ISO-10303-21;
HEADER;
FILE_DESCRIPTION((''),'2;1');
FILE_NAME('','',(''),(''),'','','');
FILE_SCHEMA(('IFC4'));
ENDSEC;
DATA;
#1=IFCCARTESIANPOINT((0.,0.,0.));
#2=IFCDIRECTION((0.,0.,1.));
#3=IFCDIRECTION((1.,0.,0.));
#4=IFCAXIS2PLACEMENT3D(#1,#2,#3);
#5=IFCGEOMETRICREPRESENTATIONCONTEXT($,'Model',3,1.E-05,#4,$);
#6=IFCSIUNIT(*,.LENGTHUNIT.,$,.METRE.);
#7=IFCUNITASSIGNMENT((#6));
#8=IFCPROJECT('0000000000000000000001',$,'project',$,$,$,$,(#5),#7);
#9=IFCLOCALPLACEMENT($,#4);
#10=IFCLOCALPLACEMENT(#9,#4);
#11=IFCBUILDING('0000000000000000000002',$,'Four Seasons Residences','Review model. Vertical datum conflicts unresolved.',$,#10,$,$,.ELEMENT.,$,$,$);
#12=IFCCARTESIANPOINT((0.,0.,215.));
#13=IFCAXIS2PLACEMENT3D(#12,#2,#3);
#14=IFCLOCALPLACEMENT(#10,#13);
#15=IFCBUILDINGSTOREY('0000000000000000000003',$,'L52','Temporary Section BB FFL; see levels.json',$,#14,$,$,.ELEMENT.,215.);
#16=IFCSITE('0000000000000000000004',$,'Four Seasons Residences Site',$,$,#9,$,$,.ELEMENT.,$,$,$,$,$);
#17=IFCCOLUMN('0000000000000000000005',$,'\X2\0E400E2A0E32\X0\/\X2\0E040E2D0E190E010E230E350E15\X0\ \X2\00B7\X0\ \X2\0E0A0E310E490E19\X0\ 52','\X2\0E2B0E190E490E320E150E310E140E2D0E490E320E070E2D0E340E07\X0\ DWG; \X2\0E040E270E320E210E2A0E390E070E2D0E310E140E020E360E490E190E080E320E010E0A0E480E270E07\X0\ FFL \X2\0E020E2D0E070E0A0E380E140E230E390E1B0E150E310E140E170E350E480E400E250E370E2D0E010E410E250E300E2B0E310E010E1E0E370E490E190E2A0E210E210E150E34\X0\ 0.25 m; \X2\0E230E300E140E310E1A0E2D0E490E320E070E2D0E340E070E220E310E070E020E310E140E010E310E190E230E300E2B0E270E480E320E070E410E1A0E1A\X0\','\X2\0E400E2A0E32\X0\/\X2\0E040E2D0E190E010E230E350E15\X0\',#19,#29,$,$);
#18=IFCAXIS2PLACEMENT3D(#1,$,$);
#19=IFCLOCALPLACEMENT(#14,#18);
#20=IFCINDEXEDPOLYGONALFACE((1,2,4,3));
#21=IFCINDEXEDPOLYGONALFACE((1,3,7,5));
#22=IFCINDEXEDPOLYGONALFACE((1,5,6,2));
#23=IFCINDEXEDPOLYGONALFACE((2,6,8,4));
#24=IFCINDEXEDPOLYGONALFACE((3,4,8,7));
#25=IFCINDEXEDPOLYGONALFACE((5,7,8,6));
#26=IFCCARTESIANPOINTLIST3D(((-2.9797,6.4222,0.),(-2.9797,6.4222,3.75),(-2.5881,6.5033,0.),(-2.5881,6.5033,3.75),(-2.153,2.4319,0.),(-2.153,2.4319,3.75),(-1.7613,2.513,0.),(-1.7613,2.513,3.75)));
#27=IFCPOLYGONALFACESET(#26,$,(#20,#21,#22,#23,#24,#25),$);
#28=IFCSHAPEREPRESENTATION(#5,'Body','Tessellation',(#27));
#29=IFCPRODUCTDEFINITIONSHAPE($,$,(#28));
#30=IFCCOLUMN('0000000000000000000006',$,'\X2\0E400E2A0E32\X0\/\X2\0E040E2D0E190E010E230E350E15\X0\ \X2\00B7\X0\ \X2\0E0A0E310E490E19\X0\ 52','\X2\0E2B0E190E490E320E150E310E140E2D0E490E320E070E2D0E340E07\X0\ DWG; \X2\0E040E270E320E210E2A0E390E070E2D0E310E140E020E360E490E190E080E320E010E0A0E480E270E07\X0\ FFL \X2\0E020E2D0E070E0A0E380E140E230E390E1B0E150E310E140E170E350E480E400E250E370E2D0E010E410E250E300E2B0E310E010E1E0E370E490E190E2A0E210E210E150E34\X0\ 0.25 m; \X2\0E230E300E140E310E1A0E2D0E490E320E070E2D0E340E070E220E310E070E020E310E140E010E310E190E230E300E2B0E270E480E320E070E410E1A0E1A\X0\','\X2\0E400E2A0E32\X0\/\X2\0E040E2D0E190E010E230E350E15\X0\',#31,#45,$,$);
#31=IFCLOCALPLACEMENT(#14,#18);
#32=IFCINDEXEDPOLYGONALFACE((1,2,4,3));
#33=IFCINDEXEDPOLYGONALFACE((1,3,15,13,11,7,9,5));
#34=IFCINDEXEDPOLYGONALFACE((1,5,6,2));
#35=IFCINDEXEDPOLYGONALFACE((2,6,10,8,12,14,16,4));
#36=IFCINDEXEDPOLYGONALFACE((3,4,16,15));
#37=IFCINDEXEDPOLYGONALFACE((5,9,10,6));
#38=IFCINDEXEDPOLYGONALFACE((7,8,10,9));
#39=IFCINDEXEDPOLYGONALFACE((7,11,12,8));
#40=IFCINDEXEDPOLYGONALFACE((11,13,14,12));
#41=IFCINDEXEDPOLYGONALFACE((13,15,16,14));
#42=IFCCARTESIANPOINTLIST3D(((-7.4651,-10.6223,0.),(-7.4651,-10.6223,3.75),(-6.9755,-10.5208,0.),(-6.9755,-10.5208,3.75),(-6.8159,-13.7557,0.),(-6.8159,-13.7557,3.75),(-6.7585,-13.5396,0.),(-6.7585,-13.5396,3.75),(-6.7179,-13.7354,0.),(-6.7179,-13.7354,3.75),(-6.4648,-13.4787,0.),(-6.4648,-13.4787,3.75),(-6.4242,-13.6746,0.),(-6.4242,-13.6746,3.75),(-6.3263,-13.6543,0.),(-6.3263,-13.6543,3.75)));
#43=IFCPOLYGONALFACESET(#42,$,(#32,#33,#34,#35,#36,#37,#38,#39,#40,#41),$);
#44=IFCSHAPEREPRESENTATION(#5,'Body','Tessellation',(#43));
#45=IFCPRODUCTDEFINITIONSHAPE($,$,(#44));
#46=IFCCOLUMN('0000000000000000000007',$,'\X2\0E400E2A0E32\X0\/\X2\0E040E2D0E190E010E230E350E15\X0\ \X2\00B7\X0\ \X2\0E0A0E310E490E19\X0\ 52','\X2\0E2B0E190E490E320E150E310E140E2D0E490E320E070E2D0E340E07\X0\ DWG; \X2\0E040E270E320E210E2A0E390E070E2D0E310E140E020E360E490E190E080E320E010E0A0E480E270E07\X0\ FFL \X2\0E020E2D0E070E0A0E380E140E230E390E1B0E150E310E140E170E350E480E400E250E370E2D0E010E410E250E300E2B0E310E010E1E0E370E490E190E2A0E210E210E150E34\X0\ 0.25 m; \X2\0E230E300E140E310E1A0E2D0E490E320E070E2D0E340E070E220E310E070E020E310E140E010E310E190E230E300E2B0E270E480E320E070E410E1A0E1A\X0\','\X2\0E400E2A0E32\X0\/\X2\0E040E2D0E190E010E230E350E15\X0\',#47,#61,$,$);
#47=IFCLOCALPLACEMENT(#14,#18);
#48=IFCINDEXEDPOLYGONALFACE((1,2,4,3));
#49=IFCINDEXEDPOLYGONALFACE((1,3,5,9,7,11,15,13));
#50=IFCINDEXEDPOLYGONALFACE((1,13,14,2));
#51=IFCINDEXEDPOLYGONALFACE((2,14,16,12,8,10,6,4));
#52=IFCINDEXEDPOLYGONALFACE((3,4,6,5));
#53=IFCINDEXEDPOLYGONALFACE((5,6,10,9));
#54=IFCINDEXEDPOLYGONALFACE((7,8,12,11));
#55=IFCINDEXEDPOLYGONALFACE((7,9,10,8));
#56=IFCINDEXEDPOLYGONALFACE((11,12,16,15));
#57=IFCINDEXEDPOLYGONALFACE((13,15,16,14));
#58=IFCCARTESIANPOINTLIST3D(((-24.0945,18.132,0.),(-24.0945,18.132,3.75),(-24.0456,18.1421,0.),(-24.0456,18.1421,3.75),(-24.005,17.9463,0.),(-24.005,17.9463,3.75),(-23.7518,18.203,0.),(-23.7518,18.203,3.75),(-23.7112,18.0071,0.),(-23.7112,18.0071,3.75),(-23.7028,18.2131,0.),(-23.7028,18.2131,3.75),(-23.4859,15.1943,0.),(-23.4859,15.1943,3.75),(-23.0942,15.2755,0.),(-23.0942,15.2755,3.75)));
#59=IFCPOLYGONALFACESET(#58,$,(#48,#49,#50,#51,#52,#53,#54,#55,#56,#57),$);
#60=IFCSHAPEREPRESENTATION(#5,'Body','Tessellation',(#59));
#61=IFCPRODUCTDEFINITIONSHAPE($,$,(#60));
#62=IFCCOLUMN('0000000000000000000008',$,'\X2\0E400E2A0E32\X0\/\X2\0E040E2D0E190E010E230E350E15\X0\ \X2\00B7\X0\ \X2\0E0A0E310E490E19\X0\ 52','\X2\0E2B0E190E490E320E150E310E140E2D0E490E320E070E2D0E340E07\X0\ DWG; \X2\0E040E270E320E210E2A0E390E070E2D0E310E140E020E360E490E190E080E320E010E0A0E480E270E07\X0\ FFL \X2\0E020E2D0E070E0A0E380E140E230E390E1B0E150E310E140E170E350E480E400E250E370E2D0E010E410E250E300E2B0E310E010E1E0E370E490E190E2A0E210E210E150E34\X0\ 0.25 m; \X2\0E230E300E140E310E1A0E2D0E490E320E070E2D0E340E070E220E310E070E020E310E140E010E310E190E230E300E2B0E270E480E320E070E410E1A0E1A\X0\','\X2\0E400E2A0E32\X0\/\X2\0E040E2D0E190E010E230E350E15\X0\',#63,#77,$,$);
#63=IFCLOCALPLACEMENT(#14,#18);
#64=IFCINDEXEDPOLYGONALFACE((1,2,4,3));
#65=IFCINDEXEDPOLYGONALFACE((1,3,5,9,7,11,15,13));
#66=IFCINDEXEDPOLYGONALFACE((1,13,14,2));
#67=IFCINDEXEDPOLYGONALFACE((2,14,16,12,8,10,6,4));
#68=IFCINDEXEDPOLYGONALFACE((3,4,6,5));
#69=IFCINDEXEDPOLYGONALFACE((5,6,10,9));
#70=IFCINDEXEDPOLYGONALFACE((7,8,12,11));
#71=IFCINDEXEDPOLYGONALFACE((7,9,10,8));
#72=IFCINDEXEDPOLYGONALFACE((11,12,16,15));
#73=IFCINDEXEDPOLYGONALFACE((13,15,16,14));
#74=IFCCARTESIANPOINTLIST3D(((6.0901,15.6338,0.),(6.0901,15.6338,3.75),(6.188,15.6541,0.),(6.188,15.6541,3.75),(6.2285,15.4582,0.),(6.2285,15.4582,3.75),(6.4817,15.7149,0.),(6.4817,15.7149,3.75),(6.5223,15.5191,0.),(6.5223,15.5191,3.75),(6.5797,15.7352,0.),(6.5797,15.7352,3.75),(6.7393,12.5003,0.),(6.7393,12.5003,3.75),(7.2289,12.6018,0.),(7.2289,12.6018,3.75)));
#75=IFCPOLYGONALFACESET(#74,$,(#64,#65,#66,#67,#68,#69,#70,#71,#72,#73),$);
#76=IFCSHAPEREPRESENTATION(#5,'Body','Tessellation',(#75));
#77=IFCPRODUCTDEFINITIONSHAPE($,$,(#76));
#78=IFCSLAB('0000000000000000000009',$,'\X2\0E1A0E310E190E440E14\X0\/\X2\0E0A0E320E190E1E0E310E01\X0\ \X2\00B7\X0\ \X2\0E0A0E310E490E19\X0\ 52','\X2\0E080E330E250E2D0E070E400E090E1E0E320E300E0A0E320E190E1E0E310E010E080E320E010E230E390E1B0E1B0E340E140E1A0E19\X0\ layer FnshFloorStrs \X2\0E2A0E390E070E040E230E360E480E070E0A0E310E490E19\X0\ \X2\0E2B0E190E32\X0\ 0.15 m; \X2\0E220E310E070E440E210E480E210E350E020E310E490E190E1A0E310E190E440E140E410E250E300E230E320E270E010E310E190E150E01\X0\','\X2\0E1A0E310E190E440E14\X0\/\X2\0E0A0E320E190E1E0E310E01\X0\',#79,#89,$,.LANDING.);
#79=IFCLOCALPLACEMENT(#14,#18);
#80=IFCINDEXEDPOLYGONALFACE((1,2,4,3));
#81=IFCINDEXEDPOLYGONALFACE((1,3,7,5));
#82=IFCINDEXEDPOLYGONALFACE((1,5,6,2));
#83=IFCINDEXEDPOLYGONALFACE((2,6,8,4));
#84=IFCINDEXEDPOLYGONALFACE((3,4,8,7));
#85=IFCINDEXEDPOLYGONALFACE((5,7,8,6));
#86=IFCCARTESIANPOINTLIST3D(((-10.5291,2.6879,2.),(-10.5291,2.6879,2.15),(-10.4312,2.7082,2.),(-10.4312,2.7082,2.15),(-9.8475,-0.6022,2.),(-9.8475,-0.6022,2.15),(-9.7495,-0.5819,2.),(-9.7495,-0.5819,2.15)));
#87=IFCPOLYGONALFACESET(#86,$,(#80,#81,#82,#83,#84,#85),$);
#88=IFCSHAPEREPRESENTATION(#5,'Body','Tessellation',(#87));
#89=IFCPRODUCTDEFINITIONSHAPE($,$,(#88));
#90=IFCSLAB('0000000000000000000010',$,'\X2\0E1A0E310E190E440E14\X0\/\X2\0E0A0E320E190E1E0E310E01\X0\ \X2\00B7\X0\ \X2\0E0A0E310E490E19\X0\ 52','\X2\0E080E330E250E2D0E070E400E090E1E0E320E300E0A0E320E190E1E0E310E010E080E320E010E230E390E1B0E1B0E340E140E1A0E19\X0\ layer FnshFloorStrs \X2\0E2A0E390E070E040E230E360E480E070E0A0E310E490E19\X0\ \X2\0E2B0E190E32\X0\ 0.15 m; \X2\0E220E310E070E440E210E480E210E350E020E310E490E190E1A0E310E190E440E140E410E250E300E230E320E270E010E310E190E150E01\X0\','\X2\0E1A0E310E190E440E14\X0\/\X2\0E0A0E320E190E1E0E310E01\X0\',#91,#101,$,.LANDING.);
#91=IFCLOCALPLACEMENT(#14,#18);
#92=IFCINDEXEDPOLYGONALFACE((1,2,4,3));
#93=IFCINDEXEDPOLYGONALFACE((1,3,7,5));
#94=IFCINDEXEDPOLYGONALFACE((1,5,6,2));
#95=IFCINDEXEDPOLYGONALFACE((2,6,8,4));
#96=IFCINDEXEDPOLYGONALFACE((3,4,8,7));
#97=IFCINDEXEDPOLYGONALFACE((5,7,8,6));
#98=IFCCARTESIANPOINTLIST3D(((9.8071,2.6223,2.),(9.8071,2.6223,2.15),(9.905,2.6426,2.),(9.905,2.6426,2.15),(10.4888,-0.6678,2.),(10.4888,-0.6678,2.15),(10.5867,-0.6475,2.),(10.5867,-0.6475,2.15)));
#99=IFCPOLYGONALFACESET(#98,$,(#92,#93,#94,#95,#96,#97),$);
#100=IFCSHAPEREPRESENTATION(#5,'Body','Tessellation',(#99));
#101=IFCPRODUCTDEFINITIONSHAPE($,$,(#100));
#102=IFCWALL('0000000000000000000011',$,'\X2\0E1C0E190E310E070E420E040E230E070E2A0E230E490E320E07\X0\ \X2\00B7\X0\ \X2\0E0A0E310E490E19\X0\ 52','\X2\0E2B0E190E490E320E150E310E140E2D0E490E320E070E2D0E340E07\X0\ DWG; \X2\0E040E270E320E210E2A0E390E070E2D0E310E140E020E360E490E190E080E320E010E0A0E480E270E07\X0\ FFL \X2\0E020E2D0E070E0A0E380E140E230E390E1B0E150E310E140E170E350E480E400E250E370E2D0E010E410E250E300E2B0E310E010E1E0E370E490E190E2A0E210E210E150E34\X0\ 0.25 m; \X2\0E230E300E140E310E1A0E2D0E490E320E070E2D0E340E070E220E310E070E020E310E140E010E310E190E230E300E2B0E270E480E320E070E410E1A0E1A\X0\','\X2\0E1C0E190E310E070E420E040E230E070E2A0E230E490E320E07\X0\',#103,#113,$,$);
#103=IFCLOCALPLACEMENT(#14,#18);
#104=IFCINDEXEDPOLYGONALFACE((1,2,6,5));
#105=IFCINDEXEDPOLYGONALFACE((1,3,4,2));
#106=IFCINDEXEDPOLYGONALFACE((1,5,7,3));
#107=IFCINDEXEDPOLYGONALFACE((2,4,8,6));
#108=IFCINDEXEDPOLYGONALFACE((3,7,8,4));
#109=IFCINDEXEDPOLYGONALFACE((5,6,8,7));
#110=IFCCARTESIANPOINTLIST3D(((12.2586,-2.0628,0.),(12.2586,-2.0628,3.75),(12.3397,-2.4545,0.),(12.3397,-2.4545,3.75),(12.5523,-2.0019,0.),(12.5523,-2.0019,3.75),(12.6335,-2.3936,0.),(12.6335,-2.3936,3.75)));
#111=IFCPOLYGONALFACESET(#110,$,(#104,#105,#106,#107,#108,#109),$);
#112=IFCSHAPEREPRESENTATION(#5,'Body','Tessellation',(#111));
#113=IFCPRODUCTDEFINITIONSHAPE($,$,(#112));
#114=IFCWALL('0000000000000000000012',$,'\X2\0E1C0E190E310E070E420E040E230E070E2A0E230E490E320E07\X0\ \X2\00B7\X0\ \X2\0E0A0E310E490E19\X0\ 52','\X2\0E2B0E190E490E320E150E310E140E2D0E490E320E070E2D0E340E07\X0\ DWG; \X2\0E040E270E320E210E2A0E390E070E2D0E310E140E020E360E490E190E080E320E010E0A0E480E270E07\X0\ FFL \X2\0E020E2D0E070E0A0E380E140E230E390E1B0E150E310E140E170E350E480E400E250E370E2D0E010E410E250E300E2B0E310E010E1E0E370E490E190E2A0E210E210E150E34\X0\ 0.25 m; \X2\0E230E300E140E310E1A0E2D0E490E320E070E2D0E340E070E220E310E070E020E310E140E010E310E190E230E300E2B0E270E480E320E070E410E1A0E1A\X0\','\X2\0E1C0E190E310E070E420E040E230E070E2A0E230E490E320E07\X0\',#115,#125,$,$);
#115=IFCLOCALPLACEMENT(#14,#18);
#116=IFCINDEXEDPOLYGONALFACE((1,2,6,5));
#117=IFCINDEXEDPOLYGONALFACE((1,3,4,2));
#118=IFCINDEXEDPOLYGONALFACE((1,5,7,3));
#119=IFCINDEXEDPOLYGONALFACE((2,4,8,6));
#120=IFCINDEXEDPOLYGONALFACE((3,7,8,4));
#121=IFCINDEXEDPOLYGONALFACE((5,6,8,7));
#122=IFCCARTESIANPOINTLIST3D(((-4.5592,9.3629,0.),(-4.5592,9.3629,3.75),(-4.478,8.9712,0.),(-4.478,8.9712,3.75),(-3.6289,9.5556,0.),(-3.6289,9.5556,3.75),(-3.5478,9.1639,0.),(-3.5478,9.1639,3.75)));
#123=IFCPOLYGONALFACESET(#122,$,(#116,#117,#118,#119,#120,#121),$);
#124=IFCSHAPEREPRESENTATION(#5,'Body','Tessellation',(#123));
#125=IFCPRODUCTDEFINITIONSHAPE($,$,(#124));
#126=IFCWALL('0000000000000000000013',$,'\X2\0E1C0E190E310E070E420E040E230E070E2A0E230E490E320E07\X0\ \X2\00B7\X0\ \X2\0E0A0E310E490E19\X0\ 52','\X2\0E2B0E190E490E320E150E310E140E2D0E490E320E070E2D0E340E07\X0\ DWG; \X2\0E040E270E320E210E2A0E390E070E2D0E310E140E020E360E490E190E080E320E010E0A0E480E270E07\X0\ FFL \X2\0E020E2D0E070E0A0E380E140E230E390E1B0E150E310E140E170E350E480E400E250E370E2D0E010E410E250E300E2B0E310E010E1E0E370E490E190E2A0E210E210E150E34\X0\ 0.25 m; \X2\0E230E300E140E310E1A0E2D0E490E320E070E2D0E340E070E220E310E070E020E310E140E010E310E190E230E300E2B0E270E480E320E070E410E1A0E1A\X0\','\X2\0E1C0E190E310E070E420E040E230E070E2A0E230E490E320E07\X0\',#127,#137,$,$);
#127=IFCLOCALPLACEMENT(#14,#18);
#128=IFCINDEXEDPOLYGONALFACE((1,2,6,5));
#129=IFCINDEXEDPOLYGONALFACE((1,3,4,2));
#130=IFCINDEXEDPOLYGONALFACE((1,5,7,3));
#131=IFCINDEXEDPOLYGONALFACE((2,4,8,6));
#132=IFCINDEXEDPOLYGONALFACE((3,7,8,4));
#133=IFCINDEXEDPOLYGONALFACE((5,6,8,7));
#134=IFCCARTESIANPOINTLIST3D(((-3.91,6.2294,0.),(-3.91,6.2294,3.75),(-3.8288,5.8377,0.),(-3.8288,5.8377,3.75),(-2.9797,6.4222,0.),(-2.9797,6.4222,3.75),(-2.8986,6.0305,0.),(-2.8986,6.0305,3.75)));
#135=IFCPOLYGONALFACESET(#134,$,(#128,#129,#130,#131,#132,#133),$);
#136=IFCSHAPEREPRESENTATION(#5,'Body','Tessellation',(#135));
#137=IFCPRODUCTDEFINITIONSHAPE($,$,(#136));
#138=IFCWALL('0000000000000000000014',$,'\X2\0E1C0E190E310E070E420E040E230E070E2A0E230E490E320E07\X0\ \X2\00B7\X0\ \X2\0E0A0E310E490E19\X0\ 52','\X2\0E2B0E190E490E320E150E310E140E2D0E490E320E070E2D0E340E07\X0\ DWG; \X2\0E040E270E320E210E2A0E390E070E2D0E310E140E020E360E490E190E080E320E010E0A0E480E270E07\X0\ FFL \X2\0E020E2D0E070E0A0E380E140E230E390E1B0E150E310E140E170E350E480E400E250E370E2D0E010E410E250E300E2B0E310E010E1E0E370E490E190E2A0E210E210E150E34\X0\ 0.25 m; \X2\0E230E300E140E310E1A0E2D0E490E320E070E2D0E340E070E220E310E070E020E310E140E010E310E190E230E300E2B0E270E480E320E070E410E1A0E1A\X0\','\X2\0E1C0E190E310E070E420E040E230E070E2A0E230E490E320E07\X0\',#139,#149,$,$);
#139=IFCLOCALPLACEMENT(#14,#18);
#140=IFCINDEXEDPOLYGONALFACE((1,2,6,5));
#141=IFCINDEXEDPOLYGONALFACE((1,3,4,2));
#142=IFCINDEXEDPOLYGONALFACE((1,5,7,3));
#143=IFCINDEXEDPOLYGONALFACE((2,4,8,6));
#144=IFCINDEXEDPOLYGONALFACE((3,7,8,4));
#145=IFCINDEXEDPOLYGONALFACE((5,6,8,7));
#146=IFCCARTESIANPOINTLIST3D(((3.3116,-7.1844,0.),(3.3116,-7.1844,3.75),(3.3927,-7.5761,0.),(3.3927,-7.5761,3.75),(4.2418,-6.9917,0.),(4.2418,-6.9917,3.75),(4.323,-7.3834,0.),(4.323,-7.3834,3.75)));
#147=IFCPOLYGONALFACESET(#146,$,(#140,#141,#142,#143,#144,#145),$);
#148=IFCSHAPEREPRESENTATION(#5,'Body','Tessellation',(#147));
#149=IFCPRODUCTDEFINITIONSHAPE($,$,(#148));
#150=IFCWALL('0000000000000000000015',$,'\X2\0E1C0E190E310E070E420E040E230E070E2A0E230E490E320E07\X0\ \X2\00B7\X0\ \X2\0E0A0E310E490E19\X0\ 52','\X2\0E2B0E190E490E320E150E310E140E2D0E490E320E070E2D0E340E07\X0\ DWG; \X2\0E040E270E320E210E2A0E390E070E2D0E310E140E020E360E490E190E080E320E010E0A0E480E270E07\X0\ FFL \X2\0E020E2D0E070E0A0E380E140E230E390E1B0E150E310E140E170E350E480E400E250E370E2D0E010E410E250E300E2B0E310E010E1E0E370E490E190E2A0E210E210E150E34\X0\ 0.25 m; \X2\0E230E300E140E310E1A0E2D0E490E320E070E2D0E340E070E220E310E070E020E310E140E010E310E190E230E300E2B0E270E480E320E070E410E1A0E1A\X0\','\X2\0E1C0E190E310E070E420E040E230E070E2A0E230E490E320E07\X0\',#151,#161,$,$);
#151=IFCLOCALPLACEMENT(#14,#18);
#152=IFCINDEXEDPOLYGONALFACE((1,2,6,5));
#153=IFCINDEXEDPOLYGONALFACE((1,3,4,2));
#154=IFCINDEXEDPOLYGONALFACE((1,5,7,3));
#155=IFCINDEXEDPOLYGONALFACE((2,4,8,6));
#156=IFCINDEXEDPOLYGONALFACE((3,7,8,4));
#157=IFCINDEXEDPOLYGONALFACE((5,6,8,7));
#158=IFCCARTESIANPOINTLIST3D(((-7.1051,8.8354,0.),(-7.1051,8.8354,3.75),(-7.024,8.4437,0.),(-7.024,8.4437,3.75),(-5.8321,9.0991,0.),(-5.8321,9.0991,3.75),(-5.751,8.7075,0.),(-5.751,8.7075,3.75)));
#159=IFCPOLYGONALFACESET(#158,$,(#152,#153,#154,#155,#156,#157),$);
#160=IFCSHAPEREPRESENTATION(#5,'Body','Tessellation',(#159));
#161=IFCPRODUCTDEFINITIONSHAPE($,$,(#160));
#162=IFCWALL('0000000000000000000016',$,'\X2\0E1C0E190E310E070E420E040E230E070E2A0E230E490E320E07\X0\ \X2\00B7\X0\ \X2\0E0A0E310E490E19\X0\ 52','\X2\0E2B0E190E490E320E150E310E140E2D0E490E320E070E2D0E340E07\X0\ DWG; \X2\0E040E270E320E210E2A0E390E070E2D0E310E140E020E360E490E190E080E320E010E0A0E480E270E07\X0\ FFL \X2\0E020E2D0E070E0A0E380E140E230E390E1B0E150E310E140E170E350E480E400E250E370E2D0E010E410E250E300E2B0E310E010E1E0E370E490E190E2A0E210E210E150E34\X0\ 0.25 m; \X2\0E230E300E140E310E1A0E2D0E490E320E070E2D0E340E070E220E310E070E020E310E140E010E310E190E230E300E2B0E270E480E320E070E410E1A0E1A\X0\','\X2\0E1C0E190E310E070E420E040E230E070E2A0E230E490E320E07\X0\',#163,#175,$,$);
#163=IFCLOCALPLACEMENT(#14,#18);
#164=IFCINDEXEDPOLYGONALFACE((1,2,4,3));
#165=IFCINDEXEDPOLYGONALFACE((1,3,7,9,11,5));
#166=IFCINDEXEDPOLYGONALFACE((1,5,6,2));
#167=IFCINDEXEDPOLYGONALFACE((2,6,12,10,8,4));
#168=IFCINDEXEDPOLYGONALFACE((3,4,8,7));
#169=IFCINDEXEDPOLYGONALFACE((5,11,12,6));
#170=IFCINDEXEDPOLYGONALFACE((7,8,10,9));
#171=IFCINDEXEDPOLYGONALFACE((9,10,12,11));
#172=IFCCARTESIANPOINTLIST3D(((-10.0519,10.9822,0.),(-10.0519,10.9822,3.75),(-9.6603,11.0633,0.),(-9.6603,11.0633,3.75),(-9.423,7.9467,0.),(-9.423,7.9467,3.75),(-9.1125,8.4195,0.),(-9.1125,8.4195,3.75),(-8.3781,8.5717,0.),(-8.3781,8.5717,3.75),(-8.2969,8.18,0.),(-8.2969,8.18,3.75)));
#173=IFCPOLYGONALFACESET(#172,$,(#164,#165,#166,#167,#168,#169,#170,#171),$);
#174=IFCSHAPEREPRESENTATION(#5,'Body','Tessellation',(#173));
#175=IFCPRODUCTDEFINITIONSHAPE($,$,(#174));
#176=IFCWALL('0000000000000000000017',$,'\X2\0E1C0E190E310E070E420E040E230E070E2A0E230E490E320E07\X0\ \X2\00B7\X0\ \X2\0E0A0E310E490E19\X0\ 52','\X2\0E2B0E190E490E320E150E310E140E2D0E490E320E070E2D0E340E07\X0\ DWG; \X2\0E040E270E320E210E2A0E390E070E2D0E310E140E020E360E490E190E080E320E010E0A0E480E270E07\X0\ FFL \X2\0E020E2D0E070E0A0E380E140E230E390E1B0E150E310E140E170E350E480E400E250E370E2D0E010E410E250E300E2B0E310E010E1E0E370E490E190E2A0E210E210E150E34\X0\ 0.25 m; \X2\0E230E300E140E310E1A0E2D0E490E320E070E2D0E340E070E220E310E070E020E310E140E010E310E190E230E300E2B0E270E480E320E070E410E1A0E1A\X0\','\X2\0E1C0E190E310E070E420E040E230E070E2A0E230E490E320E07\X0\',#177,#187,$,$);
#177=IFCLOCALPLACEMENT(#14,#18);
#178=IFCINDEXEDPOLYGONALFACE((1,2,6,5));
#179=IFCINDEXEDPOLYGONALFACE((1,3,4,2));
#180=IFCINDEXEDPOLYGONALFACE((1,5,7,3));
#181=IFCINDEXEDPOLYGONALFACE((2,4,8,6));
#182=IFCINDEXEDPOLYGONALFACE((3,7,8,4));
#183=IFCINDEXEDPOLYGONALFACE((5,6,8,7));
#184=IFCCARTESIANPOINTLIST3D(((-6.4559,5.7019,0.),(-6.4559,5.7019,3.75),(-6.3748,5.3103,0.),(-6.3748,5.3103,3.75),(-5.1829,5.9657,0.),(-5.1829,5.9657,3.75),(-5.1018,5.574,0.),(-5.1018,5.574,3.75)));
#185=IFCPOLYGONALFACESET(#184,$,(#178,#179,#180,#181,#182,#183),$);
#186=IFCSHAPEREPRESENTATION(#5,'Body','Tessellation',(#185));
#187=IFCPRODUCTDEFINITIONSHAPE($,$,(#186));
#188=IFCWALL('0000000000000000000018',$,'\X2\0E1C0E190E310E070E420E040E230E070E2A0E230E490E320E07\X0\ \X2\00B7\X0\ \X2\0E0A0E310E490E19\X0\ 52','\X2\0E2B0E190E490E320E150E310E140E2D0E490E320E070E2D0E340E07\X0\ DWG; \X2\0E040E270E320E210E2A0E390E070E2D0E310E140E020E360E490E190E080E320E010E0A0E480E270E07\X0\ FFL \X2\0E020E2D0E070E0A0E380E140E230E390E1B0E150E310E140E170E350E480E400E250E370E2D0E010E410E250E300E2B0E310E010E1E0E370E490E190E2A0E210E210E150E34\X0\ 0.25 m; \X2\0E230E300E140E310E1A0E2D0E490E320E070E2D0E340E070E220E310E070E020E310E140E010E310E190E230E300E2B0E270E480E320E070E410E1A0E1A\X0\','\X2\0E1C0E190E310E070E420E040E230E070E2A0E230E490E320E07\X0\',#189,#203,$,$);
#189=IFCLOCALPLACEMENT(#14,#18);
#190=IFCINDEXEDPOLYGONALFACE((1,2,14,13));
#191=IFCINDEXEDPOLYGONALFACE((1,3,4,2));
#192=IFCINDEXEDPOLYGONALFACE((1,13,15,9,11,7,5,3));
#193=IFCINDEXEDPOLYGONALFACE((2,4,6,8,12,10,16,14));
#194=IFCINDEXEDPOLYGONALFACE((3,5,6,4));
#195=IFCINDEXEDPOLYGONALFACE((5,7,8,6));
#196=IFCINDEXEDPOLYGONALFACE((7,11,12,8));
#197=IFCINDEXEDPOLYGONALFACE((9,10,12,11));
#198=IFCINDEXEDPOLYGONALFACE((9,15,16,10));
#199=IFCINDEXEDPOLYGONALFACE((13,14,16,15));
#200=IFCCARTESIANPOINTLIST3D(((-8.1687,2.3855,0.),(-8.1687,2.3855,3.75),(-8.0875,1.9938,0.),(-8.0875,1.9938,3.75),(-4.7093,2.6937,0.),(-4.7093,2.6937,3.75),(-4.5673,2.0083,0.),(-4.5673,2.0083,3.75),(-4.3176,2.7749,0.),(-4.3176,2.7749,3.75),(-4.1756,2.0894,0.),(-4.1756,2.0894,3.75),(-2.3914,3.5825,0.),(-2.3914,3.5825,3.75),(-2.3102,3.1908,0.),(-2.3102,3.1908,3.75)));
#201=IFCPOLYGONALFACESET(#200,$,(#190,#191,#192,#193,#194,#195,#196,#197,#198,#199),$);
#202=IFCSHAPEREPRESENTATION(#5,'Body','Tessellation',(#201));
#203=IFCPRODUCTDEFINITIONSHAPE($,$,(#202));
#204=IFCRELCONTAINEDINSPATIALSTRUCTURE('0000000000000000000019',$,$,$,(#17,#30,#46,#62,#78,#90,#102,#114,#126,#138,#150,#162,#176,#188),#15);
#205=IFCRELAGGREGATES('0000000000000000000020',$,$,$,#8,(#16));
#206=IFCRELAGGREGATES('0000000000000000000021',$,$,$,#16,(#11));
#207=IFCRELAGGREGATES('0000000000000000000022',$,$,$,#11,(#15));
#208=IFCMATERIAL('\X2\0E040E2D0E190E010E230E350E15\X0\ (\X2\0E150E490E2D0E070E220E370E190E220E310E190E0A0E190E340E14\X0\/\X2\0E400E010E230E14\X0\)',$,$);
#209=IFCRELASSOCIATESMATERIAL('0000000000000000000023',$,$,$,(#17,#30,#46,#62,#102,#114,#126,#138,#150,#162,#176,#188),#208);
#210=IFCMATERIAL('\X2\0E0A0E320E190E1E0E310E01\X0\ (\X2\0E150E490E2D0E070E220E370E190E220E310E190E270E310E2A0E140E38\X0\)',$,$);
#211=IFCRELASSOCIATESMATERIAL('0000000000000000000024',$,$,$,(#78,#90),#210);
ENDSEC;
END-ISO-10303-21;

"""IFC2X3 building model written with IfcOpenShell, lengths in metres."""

from ifc_helpers import new_model, si_unit, frame, origin_with_axes, place, context, project, spatial, polyline, outline, extrude, material, element, save


model = new_model("IFC2X3")

# Units and contexts
model_context = context("Model", 3, precision=1e-05, world=origin_with_axes())
ifc_project = project(units=[si_unit("LENGTHUNIT", "METRE")], contexts=[model_context])

# Site, building, storey
site_placement = place(None, origin_with_axes())
site = spatial("IfcSite", under=ifc_project, at=site_placement, Name="Four Seasons Residences Site", CompositionType="ELEMENT")
building_placement = place(site_placement, origin_with_axes())
building = spatial("IfcBuilding", under=site, at=building_placement, Name="Four Seasons Residences", Description="Review model. Vertical datum conflicts unresolved.", CompositionType="ELEMENT")
storey_placement = place(building_placement, frame((0.0, 0.0, 215.0), z_axis=(0.0, 0.0, 1.0), x_axis=(1.0, 0.0, 0.0)))
storey = spatial("IfcBuildingStorey", under=building, at=storey_placement, Name="L52", Description="Temporary Section BB FFL; see levels.json", CompositionType="ELEMENT", Elevation=215.0)

# Columns
ifc_material_1 = material(Name="คอนกรีต (ต้องยืนยันชนิด/เกรด)")
column_1_placement = place(storey_placement, origin_with_axes())
element("IfcColumn", 1, at=column_1_placement, inside=storey, material=ifc_material_1, Name="เสา/คอนกรีต · ชั้น 52", Description="หน้าตัดอ้างอิง DWG; ความสูงอัดขึ้นจากช่วง FFL ของชุดรูปตัดที่เลือกและหักพื้นสมมติ 0.25 m; ระดับอ้างอิงยังขัดกันระหว่างแบบ", ObjectType="เสา/คอนกรีต", context=model_context, shape_type="SweptSolid", body=[
    extrude(outline(polyline([(-2.5881, 6.5033), (-1.7613, 2.513), (-2.153, 2.4319), (-2.9797, 6.4222), (-2.5881, 6.5033)])), origin_with_axes(), (0.0, 0.0, 1.0), 3.75),
])
column_2_placement = place(storey_placement, origin_with_axes())
element("IfcColumn", 2, at=column_2_placement, inside=storey, material=ifc_material_1, Name="เสา/คอนกรีต · ชั้น 52", Description="หน้าตัดอ้างอิง DWG; ความสูงอัดขึ้นจากช่วง FFL ของชุดรูปตัดที่เลือกและหักพื้นสมมติ 0.25 m; ระดับอ้างอิงยังขัดกันระหว่างแบบ", ObjectType="เสา/คอนกรีต", context=model_context, shape_type="SweptSolid", body=[
    extrude(outline(polyline([(-6.9755, -10.5208), (-7.4651, -10.6223), (-6.8159, -13.7557), (-6.7179, -13.7354), (-6.7585, -13.5396), (-6.4648, -13.4787), (-6.4242, -13.6746), (-6.3263, -13.6543), (-6.9755, -10.5208)])), origin_with_axes(), (0.0, 0.0, 1.0), 3.75),
])
column_3_placement = place(storey_placement, origin_with_axes())
element("IfcColumn", 3, at=column_3_placement, inside=storey, material=ifc_material_1, Name="เสา/คอนกรีต · ชั้น 52", Description="หน้าตัดอ้างอิง DWG; ความสูงอัดขึ้นจากช่วง FFL ของชุดรูปตัดที่เลือกและหักพื้นสมมติ 0.25 m; ระดับอ้างอิงยังขัดกันระหว่างแบบ", ObjectType="เสา/คอนกรีต", context=model_context, shape_type="SweptSolid", body=[
    extrude(outline(polyline([(-23.7028, 18.2131), (-23.7518, 18.203), (-23.7112, 18.0071), (-24.005, 17.9463), (-24.0456, 18.1421), (-24.0945, 18.132), (-23.4859, 15.1943), (-23.0942, 15.2755), (-23.7028, 18.2131)])), origin_with_axes(), (0.0, 0.0, 1.0), 3.75),
])
column_4_placement = place(storey_placement, origin_with_axes())
element("IfcColumn", 4, at=column_4_placement, inside=storey, material=ifc_material_1, Name="เสา/คอนกรีต · ชั้น 52", Description="หน้าตัดอ้างอิง DWG; ความสูงอัดขึ้นจากช่วง FFL ของชุดรูปตัดที่เลือกและหักพื้นสมมติ 0.25 m; ระดับอ้างอิงยังขัดกันระหว่างแบบ", ObjectType="เสา/คอนกรีต", context=model_context, shape_type="SweptSolid", body=[
    extrude(outline(polyline([(6.5797, 15.7352), (6.4817, 15.7149), (6.5223, 15.5191), (6.2285, 15.4582), (6.188, 15.6541), (6.0901, 15.6338), (6.7393, 12.5003), (7.2289, 12.6018), (6.5797, 15.7352)])), origin_with_axes(), (0.0, 0.0, 1.0), 3.75),
])

# Slabs
ifc_material_2 = material(Name="ชานพัก (ต้องยืนยันวัสดุ)")
slab_1_placement = place(storey_placement, origin_with_axes())
element("IfcSlab", 5, at=slab_1_placement, inside=storey, material=ifc_material_2, Name="บันได/ชานพัก · ชั้น 52", Description="จำลองเฉพาะชานพักจากรูปปิดบน layer FnshFloorStrs สูงครึ่งชั้น หนา 0.15 m; ยังไม่มีขั้นบันไดและราวกันตก", ObjectType="บันได/ชานพัก", PredefinedType="LANDING", context=model_context, shape_type="SweptSolid", body=[
    extrude(outline(polyline([(-10.5291, 2.6879), (-10.4312, 2.7082), (-9.7495, -0.5819), (-9.8475, -0.6022), (-10.5291, 2.6879)])), frame((0.0, 0.0, 2.0), z_axis=(0.0, 0.0, 1.0), x_axis=(1.0, 0.0, 0.0)), (0.0, 0.0, 1.0), 0.15),
])
slab_2_placement = place(storey_placement, origin_with_axes())
element("IfcSlab", 6, at=slab_2_placement, inside=storey, material=ifc_material_2, Name="บันได/ชานพัก · ชั้น 52", Description="จำลองเฉพาะชานพักจากรูปปิดบน layer FnshFloorStrs สูงครึ่งชั้น หนา 0.15 m; ยังไม่มีขั้นบันไดและราวกันตก", ObjectType="บันได/ชานพัก", PredefinedType="LANDING", context=model_context, shape_type="SweptSolid", body=[
    extrude(outline(polyline([(10.5867, -0.6475), (10.4888, -0.6678), (9.8071, 2.6223), (9.905, 2.6426), (10.5867, -0.6475)])), frame((0.0, 0.0, 2.0), z_axis=(0.0, 0.0, 1.0), x_axis=(1.0, 0.0, 0.0)), (0.0, 0.0, 1.0), 0.15),
])

# Walls
wall_1_placement = place(storey_placement, origin_with_axes())
element("IfcWall", 7, at=wall_1_placement, inside=storey, material=ifc_material_1, Name="ผนังโครงสร้าง · ชั้น 52", Description="หน้าตัดอ้างอิง DWG; ความสูงอัดขึ้นจากช่วง FFL ของชุดรูปตัดที่เลือกและหักพื้นสมมติ 0.25 m; ระดับอ้างอิงยังขัดกันระหว่างแบบ", ObjectType="ผนังโครงสร้าง", context=model_context, shape_type="SweptSolid", body=[
    extrude(outline(polyline([(12.2586, -2.0628), (12.3397, -2.4545), (12.6335, -2.3936), (12.5523, -2.0019), (12.2586, -2.0628)])), origin_with_axes(), (0.0, 0.0, 1.0), 3.75),
])
wall_2_placement = place(storey_placement, origin_with_axes())
element("IfcWall", 8, at=wall_2_placement, inside=storey, material=ifc_material_1, Name="ผนังโครงสร้าง · ชั้น 52", Description="หน้าตัดอ้างอิง DWG; ความสูงอัดขึ้นจากช่วง FFL ของชุดรูปตัดที่เลือกและหักพื้นสมมติ 0.25 m; ระดับอ้างอิงยังขัดกันระหว่างแบบ", ObjectType="ผนังโครงสร้าง", context=model_context, shape_type="SweptSolid", body=[
    extrude(outline(polyline([(-4.5592, 9.3629), (-4.478, 8.9712), (-3.5478, 9.1639), (-3.6289, 9.5556), (-4.5592, 9.3629)])), origin_with_axes(), (0.0, 0.0, 1.0), 3.75),
])
wall_3_placement = place(storey_placement, origin_with_axes())
element("IfcWall", 9, at=wall_3_placement, inside=storey, material=ifc_material_1, Name="ผนังโครงสร้าง · ชั้น 52", Description="หน้าตัดอ้างอิง DWG; ความสูงอัดขึ้นจากช่วง FFL ของชุดรูปตัดที่เลือกและหักพื้นสมมติ 0.25 m; ระดับอ้างอิงยังขัดกันระหว่างแบบ", ObjectType="ผนังโครงสร้าง", context=model_context, shape_type="SweptSolid", body=[
    extrude(outline(polyline([(-2.9797, 6.4222), (-2.8986, 6.0305), (-3.8288, 5.8377), (-3.91, 6.2294), (-2.9797, 6.4222)])), origin_with_axes(), (0.0, 0.0, 1.0), 3.75),
])
wall_4_placement = place(storey_placement, origin_with_axes())
element("IfcWall", 10, at=wall_4_placement, inside=storey, material=ifc_material_1, Name="ผนังโครงสร้าง · ชั้น 52", Description="หน้าตัดอ้างอิง DWG; ความสูงอัดขึ้นจากช่วง FFL ของชุดรูปตัดที่เลือกและหักพื้นสมมติ 0.25 m; ระดับอ้างอิงยังขัดกันระหว่างแบบ", ObjectType="ผนังโครงสร้าง", context=model_context, shape_type="SweptSolid", body=[
    extrude(outline(polyline([(4.323, -7.3834), (4.2418, -6.9917), (3.3116, -7.1844), (3.3927, -7.5761), (4.323, -7.3834)])), origin_with_axes(), (0.0, 0.0, 1.0), 3.75),
])
wall_5_placement = place(storey_placement, origin_with_axes())
element("IfcWall", 11, at=wall_5_placement, inside=storey, material=ifc_material_1, Name="ผนังโครงสร้าง · ชั้น 52", Description="หน้าตัดอ้างอิง DWG; ความสูงอัดขึ้นจากช่วง FFL ของชุดรูปตัดที่เลือกและหักพื้นสมมติ 0.25 m; ระดับอ้างอิงยังขัดกันระหว่างแบบ", ObjectType="ผนังโครงสร้าง", context=model_context, shape_type="SweptSolid", body=[
    extrude(outline(polyline([(-5.751, 8.7075), (-5.8321, 9.0991), (-7.1051, 8.8354), (-7.024, 8.4437), (-5.751, 8.7075)])), origin_with_axes(), (0.0, 0.0, 1.0), 3.75),
])
wall_6_placement = place(storey_placement, origin_with_axes())
element("IfcWall", 12, at=wall_6_placement, inside=storey, material=ifc_material_1, Name="ผนังโครงสร้าง · ชั้น 52", Description="หน้าตัดอ้างอิง DWG; ความสูงอัดขึ้นจากช่วง FFL ของชุดรูปตัดที่เลือกและหักพื้นสมมติ 0.25 m; ระดับอ้างอิงยังขัดกันระหว่างแบบ", ObjectType="ผนังโครงสร้าง", context=model_context, shape_type="SweptSolid", body=[
    extrude(outline(polyline([(-9.423, 7.9467), (-8.2969, 8.18), (-8.3781, 8.5717), (-9.1125, 8.4195), (-9.6603, 11.0633), (-10.0519, 10.9822), (-9.423, 7.9467)])), origin_with_axes(), (0.0, 0.0, 1.0), 3.75),
])
wall_7_placement = place(storey_placement, origin_with_axes())
element("IfcWall", 13, at=wall_7_placement, inside=storey, material=ifc_material_1, Name="ผนังโครงสร้าง · ชั้น 52", Description="หน้าตัดอ้างอิง DWG; ความสูงอัดขึ้นจากช่วง FFL ของชุดรูปตัดที่เลือกและหักพื้นสมมติ 0.25 m; ระดับอ้างอิงยังขัดกันระหว่างแบบ", ObjectType="ผนังโครงสร้าง", context=model_context, shape_type="SweptSolid", body=[
    extrude(outline(polyline([(-6.3748, 5.3103), (-6.4559, 5.7019), (-5.1829, 5.9657), (-5.1018, 5.574), (-6.3748, 5.3103)])), origin_with_axes(), (0.0, 0.0, 1.0), 3.75),
])
wall_8_placement = place(storey_placement, origin_with_axes())
element("IfcWall", 14, at=wall_8_placement, inside=storey, material=ifc_material_1, Name="ผนังโครงสร้าง · ชั้น 52", Description="หน้าตัดอ้างอิง DWG; ความสูงอัดขึ้นจากช่วง FFL ของชุดรูปตัดที่เลือกและหักพื้นสมมติ 0.25 m; ระดับอ้างอิงยังขัดกันระหว่างแบบ", ObjectType="ผนังโครงสร้าง", context=model_context, shape_type="SweptSolid", body=[
    extrude(outline(polyline([(-2.3914, 3.5825), (-2.3102, 3.1908), (-4.3176, 2.7749), (-4.1756, 2.0894), (-4.5673, 2.0083), (-4.7093, 2.6937), (-8.0875, 1.9938), (-8.1687, 2.3855), (-2.3914, 3.5825)])), origin_with_axes(), (0.0, 0.0, 1.0), 3.75),
])

save(model, "model.ifc")
